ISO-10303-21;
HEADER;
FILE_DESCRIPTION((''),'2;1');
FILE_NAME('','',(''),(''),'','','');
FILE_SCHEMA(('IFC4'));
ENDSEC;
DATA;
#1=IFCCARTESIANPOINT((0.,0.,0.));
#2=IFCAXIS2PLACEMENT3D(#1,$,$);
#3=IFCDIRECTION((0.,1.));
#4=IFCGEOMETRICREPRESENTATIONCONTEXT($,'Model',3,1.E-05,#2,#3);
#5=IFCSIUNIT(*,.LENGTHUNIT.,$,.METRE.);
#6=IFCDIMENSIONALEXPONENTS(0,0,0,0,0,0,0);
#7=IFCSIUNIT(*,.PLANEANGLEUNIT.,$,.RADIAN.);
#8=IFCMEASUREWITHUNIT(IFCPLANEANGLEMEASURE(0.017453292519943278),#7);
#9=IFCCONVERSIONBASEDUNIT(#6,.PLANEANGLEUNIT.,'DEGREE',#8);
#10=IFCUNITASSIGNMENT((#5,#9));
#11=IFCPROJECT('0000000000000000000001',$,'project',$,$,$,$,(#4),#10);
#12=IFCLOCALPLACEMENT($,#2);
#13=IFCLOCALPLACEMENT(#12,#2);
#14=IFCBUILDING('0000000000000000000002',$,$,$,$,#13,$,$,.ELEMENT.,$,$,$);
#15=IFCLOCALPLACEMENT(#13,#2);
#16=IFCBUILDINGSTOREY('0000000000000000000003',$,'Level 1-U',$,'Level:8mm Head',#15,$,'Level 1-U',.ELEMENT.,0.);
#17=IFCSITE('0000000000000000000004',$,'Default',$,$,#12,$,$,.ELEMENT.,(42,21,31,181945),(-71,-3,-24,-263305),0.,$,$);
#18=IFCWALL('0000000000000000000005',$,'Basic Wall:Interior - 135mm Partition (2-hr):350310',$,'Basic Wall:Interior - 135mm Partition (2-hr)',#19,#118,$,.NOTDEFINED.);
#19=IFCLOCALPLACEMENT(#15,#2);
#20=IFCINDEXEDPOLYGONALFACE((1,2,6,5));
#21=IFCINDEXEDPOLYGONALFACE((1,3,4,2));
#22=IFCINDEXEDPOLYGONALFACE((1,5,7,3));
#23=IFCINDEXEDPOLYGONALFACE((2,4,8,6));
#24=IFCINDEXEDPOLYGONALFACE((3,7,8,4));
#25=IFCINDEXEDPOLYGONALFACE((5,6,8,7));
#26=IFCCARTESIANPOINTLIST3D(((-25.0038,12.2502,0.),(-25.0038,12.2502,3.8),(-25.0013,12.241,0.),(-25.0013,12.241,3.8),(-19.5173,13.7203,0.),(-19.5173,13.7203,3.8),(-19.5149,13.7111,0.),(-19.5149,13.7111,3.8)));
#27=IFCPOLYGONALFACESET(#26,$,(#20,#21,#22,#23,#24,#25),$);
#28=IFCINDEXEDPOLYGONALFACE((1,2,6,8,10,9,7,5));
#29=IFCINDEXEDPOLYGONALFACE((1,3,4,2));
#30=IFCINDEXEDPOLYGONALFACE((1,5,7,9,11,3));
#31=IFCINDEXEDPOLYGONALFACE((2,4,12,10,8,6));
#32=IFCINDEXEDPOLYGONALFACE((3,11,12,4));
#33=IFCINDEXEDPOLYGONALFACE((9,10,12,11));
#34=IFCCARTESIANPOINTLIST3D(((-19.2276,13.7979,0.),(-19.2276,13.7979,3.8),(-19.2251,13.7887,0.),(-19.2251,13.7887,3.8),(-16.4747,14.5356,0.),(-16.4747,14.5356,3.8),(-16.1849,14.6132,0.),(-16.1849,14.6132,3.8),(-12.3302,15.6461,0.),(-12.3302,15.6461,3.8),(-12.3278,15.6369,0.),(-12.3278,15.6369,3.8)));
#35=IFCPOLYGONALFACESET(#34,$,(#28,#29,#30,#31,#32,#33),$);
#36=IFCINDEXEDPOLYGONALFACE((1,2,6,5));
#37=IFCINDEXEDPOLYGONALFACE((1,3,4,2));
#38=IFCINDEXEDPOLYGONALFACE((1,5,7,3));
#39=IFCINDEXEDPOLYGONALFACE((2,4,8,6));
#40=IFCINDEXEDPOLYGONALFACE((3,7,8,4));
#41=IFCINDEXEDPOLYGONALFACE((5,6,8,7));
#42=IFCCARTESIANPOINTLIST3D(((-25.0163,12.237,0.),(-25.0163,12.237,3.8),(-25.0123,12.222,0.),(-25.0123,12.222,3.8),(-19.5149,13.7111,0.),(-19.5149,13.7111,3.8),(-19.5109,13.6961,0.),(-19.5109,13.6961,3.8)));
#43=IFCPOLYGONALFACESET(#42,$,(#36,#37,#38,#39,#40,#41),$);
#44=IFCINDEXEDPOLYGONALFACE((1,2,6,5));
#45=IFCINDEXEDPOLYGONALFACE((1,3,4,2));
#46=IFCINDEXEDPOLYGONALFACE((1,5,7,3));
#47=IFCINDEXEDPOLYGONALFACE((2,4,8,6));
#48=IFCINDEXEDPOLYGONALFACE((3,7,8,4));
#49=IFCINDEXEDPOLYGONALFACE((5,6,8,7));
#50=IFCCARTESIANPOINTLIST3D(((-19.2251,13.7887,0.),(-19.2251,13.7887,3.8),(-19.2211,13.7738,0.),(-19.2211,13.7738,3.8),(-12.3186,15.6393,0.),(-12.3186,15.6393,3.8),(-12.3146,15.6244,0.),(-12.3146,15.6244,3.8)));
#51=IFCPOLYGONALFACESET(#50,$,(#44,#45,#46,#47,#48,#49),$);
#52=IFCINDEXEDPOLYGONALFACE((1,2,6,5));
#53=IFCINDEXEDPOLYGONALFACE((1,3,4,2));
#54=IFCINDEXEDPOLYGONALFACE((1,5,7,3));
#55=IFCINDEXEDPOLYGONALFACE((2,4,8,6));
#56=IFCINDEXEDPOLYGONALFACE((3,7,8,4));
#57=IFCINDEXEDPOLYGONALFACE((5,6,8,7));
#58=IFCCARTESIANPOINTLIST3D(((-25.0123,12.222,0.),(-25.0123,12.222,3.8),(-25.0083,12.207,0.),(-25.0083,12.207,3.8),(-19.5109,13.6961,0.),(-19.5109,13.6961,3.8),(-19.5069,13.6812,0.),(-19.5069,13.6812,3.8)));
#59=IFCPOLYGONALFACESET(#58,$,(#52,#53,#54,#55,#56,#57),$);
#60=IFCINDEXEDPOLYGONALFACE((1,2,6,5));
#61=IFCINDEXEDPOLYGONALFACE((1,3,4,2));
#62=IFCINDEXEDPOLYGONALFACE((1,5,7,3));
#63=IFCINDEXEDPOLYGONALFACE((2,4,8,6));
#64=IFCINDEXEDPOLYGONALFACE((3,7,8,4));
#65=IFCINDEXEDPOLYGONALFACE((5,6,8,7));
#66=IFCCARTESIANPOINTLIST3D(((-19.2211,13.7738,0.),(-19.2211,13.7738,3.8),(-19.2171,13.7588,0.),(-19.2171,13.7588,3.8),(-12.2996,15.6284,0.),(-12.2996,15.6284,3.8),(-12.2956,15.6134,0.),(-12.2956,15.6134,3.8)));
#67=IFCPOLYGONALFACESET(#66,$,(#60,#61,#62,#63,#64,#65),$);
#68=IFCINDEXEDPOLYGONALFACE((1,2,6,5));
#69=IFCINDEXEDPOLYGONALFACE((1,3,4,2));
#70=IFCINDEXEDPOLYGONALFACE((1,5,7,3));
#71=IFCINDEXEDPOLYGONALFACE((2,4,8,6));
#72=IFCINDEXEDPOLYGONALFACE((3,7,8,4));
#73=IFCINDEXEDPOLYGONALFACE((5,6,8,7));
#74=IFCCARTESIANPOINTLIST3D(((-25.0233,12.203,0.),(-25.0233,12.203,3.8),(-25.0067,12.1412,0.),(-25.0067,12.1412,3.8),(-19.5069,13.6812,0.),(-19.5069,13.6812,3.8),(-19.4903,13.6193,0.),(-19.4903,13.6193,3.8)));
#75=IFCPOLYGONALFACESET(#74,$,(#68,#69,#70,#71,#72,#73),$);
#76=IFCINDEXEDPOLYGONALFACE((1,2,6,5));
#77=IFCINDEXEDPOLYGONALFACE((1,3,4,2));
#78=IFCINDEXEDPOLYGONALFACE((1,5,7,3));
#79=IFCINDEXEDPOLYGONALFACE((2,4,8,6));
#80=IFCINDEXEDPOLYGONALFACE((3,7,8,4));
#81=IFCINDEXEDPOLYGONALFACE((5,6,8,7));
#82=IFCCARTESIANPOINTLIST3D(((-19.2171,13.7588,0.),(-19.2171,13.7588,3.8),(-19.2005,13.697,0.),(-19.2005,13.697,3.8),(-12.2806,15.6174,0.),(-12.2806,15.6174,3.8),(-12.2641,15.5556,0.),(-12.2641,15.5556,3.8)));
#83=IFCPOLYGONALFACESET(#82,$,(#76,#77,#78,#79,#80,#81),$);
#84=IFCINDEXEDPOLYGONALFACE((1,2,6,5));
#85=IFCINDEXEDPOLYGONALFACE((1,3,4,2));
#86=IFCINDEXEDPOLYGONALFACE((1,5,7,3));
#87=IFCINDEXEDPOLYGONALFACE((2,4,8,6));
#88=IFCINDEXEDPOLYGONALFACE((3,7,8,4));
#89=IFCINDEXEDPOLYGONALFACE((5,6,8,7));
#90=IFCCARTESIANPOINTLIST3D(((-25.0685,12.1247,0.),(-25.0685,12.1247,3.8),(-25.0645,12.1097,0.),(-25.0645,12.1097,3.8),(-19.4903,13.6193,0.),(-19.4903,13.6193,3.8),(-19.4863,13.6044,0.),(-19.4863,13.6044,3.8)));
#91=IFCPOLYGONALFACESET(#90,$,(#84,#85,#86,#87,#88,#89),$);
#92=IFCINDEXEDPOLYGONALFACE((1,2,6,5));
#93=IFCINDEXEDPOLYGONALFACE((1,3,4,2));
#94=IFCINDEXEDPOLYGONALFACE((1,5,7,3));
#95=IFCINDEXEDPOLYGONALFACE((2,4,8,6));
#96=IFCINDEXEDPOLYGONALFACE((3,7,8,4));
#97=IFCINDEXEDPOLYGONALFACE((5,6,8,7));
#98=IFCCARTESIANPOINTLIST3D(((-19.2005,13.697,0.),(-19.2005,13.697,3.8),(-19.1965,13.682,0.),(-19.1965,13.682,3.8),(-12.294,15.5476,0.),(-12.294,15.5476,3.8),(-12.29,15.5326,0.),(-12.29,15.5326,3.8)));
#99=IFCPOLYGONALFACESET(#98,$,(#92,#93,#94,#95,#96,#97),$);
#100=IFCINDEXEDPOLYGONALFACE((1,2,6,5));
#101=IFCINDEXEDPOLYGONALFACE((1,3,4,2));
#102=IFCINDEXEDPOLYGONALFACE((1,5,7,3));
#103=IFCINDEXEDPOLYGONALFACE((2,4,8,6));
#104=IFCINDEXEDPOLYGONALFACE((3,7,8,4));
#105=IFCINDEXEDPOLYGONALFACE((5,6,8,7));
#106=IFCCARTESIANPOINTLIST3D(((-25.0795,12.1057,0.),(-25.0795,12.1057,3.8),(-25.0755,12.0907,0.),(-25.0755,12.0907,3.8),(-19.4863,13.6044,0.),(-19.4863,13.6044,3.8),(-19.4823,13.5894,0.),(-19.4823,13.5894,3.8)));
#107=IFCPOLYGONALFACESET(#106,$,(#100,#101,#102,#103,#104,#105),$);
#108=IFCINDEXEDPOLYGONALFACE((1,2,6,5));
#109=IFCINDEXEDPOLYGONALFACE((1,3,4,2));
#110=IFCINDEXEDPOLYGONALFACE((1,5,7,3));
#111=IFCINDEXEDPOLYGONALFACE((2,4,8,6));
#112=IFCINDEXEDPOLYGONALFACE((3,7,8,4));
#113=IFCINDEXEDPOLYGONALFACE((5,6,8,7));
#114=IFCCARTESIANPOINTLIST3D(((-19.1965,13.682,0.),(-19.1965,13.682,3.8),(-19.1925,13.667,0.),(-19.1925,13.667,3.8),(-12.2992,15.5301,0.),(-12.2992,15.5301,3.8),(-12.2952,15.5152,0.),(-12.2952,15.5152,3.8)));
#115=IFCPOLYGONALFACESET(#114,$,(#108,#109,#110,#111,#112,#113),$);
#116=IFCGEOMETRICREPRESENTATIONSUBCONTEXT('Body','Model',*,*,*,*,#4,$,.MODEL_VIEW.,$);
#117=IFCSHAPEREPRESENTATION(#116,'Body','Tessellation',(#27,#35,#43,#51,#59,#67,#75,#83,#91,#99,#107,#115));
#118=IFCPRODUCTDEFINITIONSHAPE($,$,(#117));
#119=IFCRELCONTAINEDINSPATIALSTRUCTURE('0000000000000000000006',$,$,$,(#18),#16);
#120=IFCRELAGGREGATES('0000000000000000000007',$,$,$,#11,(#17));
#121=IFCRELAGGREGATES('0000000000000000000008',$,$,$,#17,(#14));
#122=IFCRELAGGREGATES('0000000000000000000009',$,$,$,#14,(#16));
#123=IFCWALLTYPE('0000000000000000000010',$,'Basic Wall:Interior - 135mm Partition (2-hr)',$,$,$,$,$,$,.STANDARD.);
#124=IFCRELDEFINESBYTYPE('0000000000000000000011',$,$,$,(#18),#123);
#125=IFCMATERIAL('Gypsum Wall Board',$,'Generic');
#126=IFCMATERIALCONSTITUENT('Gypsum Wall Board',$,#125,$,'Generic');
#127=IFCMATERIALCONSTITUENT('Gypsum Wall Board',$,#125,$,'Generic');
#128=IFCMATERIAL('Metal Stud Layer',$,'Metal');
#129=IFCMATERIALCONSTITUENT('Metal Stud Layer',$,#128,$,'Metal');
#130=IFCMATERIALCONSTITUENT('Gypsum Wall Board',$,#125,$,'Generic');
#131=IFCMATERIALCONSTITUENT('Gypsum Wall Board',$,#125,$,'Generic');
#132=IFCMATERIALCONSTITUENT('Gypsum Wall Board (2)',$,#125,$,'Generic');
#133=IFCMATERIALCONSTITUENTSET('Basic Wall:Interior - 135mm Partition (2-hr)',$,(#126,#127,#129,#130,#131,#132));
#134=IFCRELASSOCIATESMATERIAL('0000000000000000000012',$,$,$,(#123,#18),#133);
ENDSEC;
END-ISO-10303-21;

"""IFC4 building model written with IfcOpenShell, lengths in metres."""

from ifc_helpers import new_model, entity, si_unit, converted_unit, direction, frame, origin, place, context, subcontext, project, spatial, indexed_curve, outline, extrude, material, constituent, constituent_set, type_object, element, save


model = new_model("IFC4")

# Units and contexts
model_context = context("Model", 3, precision=1e-05, world=origin(), true_north=direction((0.0, 1.0)))
body_context = subcontext(model_context, "Body", "Model", "MODEL_VIEW")
ifc_project = project(units=[si_unit("LENGTHUNIT", "METRE"), converted_unit("PLANEANGLEUNIT", "DEGREE", entity("IfcPlaneAngleMeasure", 0.017453292519943278), si_unit("PLANEANGLEUNIT", "RADIAN"), dimensions=[0, 0, 0, 0, 0, 0, 0])], contexts=[model_context])

# Site, building, storey
site_placement = place(None, origin())
site = spatial("IfcSite", under=ifc_project, at=site_placement, Name="Default", CompositionType="ELEMENT", RefLatitude=(42, 21, 31, 181945), RefLongitude=(-71, -3, -24, -263305), RefElevation=0.0)
building_placement = place(site_placement, origin())
building = spatial("IfcBuilding", under=site, at=building_placement, CompositionType="ELEMENT")
storey_placement = place(building_placement, origin())
storey = spatial("IfcBuildingStorey", under=building, at=storey_placement, Name="Level 1-U", ObjectType="Level:8mm Head", LongName="Level 1-U", CompositionType="ELEMENT", Elevation=0.0)

# Wall
ifc_material_1 = material(Name="Gypsum Wall Board", Category="Generic")
ifc_constituent_1 = constituent(ifc_material_1, Name="Gypsum Wall Board", Category="Generic")
ifc_constituent_2 = constituent(ifc_material_1, Name="Gypsum Wall Board", Category="Generic")
ifc_material_2 = material(Name="Metal Stud Layer", Category="Metal")
ifc_constituent_3 = constituent(ifc_material_2, Name="Metal Stud Layer", Category="Metal")
ifc_constituent_4 = constituent(ifc_material_1, Name="Gypsum Wall Board", Category="Generic")
ifc_constituent_5 = constituent(ifc_material_1, Name="Gypsum Wall Board", Category="Generic")
ifc_constituent_6 = constituent(ifc_material_1, Name="Gypsum Wall Board (2)", Category="Generic")
ifc_constituent_set = constituent_set(constituents=[ifc_constituent_1, ifc_constituent_2, ifc_constituent_3, ifc_constituent_4, ifc_constituent_5, ifc_constituent_6], Name="Basic Wall:Interior - 135mm Partition (2-hr)")
wall_type = type_object("IfcWallType", Name="Basic Wall:Interior - 135mm Partition (2-hr)", PredefinedType="STANDARD", material=ifc_constituent_set)
wall_1_placement = place(storey_placement, frame((-12.3127, 15.5806, 0.0), z_axis=(0.0, 0.0, 1.0), x_axis=(-0.965926, -0.258819, 0.0)))
element("IfcWall", 1, at=wall_1_placement, inside=storey, type_object=wall_type, material=ifc_constituent_set, Name="Basic Wall:Interior - 135mm Partition (2-hr):350310", ObjectType="Basic Wall:Interior - 135mm Partition (2-hr)", PredefinedType="NOTDEFINED", context=body_context, shape_type="SweptSolid", body=[
    extrude(outline(indexed_curve([(-0.0048, -2.84), (0.0047, -2.84), (0.0048, 2.84), (-0.0047, 2.84), (-0.0048, -2.84)], self_intersect=False)), frame((10.2807, -0.063, 0.0), z_axis=(0.0, 0.0, 1.0), x_axis=(0.0, 1.0, 0.0)), (0.0, 0.0, 1.0), 3.8),
    extrude(outline(indexed_curve([(0.2302, -0.0032), (0.5302, -0.0032), (3.3802, -0.0032), (3.3802, 0.0063), (-3.7604, 0.0063), (-3.7604, -0.0032), (0.2302, -0.0032)], self_intersect=False)), frame((3.7604, -0.0646, 0.0)), (0.0, 0.0, 1.0), 3.8),
    extrude(outline(indexed_curve([(-2.8477, -0.0078), (2.8477, -0.0077), (2.8477, 0.0078), (-2.8477, 0.0077), (-2.8477, -0.0078)], self_intersect=False)), frame((10.2884, -0.0505, 0.0), z_axis=(0.0, 0.0, 1.0), x_axis=(-1.0, 0.0, 0.0)), (0.0, 0.0, 1.0), 3.8),
    extrude(outline(indexed_curve([(-3.5751, -0.0077), (3.5751, -0.0078), (3.5751, 0.0077), (-3.5751, 0.0078), (-3.5751, -0.0077)], self_intersect=False)), frame((3.5656, -0.0505, 0.0)), (0.0, 0.0, 1.0), 3.8),
    extrude(outline(indexed_curve([(-2.8477, -0.0077), (2.8477, -0.0078), (2.8477, 0.0077), (-2.8477, 0.0078), (-2.8477, -0.0077)], self_intersect=False)), frame((10.2884, -0.035, 0.0), z_axis=(0.0, 0.0, 1.0), x_axis=(-1.0, 0.0, 0.0)), (0.0, 0.0, 1.0), 3.8),
    extrude(outline(indexed_curve([(-3.5828, -0.0078), (3.5828, -0.0077), (3.5828, 0.0078), (-3.5828, 0.0077), (-3.5828, -0.0078)], self_intersect=False)), frame((3.5578, -0.035, 0.0)), (0.0, 0.0, 1.0), 3.8),
    extrude(outline(indexed_curve([(-2.8555, -0.032), (2.8555, -0.032), (2.8555, 0.032), (-2.8555, 0.032), (-2.8555, -0.032)], self_intersect=False)), frame((10.2962, 0.0047, 0.0), z_axis=(0.0, 0.0, 1.0), x_axis=(-1.0, 0.0, 0.0)), (0.0, 0.0, 1.0), 3.8),
    extrude(outline(indexed_curve([(-3.5906, -0.032), (3.5906, -0.032), (3.5906, 0.032), (-3.5906, 0.032), (-3.5906, -0.032)], self_intersect=False)), frame((3.5501, 0.0048, 0.0)), (0.0, 0.0, 1.0), 3.8),
    extrude(outline(indexed_curve([(-2.8875, -0.0077), (2.8875, -0.0078), (2.8875, 0.0077), (-2.8875, 0.0078), (-2.8875, -0.0077)], self_intersect=False)), frame((10.3282, 0.0445, 0.0), z_axis=(0.0, 0.0, 1.0), x_axis=(-1.0, 0.0, 0.0)), (0.0, 0.0, 1.0), 3.8),
    extrude(outline(indexed_curve([(-3.5751, -0.0078), (3.5751, -0.0077), (3.5751, 0.0078), (-3.5751, 0.0077), (-3.5751, -0.0078)], self_intersect=False)), frame((3.5656, 0.0445, 0.0)), (0.0, 0.0, 1.0), 3.8),
    extrude(outline(indexed_curve([(-0.0078, -2.8952), (0.0077, -2.8952), (0.0078, 2.8952), (-0.0077, 2.8952), (-0.0078, -2.8952)], self_intersect=False)), frame((10.3359, 0.06, 0.0), z_axis=(0.0, 0.0, 1.0), x_axis=(0.0, -1.0, 0.0)), (0.0, 0.0, 1.0), 3.8),
    extrude(outline(indexed_curve([(-0.0077, -3.5703), (0.0078, -3.5703), (0.0077, 3.5703), (-0.0078, 3.5703), (-0.0077, -3.5703)], self_intersect=False)), frame((3.5703, 0.06, 0.0), z_axis=(0.0, 0.0, 1.0), x_axis=(0.0, -1.0, 0.0)), (0.0, 0.0, 1.0), 3.8),
])

save(model, "model.ifc")
